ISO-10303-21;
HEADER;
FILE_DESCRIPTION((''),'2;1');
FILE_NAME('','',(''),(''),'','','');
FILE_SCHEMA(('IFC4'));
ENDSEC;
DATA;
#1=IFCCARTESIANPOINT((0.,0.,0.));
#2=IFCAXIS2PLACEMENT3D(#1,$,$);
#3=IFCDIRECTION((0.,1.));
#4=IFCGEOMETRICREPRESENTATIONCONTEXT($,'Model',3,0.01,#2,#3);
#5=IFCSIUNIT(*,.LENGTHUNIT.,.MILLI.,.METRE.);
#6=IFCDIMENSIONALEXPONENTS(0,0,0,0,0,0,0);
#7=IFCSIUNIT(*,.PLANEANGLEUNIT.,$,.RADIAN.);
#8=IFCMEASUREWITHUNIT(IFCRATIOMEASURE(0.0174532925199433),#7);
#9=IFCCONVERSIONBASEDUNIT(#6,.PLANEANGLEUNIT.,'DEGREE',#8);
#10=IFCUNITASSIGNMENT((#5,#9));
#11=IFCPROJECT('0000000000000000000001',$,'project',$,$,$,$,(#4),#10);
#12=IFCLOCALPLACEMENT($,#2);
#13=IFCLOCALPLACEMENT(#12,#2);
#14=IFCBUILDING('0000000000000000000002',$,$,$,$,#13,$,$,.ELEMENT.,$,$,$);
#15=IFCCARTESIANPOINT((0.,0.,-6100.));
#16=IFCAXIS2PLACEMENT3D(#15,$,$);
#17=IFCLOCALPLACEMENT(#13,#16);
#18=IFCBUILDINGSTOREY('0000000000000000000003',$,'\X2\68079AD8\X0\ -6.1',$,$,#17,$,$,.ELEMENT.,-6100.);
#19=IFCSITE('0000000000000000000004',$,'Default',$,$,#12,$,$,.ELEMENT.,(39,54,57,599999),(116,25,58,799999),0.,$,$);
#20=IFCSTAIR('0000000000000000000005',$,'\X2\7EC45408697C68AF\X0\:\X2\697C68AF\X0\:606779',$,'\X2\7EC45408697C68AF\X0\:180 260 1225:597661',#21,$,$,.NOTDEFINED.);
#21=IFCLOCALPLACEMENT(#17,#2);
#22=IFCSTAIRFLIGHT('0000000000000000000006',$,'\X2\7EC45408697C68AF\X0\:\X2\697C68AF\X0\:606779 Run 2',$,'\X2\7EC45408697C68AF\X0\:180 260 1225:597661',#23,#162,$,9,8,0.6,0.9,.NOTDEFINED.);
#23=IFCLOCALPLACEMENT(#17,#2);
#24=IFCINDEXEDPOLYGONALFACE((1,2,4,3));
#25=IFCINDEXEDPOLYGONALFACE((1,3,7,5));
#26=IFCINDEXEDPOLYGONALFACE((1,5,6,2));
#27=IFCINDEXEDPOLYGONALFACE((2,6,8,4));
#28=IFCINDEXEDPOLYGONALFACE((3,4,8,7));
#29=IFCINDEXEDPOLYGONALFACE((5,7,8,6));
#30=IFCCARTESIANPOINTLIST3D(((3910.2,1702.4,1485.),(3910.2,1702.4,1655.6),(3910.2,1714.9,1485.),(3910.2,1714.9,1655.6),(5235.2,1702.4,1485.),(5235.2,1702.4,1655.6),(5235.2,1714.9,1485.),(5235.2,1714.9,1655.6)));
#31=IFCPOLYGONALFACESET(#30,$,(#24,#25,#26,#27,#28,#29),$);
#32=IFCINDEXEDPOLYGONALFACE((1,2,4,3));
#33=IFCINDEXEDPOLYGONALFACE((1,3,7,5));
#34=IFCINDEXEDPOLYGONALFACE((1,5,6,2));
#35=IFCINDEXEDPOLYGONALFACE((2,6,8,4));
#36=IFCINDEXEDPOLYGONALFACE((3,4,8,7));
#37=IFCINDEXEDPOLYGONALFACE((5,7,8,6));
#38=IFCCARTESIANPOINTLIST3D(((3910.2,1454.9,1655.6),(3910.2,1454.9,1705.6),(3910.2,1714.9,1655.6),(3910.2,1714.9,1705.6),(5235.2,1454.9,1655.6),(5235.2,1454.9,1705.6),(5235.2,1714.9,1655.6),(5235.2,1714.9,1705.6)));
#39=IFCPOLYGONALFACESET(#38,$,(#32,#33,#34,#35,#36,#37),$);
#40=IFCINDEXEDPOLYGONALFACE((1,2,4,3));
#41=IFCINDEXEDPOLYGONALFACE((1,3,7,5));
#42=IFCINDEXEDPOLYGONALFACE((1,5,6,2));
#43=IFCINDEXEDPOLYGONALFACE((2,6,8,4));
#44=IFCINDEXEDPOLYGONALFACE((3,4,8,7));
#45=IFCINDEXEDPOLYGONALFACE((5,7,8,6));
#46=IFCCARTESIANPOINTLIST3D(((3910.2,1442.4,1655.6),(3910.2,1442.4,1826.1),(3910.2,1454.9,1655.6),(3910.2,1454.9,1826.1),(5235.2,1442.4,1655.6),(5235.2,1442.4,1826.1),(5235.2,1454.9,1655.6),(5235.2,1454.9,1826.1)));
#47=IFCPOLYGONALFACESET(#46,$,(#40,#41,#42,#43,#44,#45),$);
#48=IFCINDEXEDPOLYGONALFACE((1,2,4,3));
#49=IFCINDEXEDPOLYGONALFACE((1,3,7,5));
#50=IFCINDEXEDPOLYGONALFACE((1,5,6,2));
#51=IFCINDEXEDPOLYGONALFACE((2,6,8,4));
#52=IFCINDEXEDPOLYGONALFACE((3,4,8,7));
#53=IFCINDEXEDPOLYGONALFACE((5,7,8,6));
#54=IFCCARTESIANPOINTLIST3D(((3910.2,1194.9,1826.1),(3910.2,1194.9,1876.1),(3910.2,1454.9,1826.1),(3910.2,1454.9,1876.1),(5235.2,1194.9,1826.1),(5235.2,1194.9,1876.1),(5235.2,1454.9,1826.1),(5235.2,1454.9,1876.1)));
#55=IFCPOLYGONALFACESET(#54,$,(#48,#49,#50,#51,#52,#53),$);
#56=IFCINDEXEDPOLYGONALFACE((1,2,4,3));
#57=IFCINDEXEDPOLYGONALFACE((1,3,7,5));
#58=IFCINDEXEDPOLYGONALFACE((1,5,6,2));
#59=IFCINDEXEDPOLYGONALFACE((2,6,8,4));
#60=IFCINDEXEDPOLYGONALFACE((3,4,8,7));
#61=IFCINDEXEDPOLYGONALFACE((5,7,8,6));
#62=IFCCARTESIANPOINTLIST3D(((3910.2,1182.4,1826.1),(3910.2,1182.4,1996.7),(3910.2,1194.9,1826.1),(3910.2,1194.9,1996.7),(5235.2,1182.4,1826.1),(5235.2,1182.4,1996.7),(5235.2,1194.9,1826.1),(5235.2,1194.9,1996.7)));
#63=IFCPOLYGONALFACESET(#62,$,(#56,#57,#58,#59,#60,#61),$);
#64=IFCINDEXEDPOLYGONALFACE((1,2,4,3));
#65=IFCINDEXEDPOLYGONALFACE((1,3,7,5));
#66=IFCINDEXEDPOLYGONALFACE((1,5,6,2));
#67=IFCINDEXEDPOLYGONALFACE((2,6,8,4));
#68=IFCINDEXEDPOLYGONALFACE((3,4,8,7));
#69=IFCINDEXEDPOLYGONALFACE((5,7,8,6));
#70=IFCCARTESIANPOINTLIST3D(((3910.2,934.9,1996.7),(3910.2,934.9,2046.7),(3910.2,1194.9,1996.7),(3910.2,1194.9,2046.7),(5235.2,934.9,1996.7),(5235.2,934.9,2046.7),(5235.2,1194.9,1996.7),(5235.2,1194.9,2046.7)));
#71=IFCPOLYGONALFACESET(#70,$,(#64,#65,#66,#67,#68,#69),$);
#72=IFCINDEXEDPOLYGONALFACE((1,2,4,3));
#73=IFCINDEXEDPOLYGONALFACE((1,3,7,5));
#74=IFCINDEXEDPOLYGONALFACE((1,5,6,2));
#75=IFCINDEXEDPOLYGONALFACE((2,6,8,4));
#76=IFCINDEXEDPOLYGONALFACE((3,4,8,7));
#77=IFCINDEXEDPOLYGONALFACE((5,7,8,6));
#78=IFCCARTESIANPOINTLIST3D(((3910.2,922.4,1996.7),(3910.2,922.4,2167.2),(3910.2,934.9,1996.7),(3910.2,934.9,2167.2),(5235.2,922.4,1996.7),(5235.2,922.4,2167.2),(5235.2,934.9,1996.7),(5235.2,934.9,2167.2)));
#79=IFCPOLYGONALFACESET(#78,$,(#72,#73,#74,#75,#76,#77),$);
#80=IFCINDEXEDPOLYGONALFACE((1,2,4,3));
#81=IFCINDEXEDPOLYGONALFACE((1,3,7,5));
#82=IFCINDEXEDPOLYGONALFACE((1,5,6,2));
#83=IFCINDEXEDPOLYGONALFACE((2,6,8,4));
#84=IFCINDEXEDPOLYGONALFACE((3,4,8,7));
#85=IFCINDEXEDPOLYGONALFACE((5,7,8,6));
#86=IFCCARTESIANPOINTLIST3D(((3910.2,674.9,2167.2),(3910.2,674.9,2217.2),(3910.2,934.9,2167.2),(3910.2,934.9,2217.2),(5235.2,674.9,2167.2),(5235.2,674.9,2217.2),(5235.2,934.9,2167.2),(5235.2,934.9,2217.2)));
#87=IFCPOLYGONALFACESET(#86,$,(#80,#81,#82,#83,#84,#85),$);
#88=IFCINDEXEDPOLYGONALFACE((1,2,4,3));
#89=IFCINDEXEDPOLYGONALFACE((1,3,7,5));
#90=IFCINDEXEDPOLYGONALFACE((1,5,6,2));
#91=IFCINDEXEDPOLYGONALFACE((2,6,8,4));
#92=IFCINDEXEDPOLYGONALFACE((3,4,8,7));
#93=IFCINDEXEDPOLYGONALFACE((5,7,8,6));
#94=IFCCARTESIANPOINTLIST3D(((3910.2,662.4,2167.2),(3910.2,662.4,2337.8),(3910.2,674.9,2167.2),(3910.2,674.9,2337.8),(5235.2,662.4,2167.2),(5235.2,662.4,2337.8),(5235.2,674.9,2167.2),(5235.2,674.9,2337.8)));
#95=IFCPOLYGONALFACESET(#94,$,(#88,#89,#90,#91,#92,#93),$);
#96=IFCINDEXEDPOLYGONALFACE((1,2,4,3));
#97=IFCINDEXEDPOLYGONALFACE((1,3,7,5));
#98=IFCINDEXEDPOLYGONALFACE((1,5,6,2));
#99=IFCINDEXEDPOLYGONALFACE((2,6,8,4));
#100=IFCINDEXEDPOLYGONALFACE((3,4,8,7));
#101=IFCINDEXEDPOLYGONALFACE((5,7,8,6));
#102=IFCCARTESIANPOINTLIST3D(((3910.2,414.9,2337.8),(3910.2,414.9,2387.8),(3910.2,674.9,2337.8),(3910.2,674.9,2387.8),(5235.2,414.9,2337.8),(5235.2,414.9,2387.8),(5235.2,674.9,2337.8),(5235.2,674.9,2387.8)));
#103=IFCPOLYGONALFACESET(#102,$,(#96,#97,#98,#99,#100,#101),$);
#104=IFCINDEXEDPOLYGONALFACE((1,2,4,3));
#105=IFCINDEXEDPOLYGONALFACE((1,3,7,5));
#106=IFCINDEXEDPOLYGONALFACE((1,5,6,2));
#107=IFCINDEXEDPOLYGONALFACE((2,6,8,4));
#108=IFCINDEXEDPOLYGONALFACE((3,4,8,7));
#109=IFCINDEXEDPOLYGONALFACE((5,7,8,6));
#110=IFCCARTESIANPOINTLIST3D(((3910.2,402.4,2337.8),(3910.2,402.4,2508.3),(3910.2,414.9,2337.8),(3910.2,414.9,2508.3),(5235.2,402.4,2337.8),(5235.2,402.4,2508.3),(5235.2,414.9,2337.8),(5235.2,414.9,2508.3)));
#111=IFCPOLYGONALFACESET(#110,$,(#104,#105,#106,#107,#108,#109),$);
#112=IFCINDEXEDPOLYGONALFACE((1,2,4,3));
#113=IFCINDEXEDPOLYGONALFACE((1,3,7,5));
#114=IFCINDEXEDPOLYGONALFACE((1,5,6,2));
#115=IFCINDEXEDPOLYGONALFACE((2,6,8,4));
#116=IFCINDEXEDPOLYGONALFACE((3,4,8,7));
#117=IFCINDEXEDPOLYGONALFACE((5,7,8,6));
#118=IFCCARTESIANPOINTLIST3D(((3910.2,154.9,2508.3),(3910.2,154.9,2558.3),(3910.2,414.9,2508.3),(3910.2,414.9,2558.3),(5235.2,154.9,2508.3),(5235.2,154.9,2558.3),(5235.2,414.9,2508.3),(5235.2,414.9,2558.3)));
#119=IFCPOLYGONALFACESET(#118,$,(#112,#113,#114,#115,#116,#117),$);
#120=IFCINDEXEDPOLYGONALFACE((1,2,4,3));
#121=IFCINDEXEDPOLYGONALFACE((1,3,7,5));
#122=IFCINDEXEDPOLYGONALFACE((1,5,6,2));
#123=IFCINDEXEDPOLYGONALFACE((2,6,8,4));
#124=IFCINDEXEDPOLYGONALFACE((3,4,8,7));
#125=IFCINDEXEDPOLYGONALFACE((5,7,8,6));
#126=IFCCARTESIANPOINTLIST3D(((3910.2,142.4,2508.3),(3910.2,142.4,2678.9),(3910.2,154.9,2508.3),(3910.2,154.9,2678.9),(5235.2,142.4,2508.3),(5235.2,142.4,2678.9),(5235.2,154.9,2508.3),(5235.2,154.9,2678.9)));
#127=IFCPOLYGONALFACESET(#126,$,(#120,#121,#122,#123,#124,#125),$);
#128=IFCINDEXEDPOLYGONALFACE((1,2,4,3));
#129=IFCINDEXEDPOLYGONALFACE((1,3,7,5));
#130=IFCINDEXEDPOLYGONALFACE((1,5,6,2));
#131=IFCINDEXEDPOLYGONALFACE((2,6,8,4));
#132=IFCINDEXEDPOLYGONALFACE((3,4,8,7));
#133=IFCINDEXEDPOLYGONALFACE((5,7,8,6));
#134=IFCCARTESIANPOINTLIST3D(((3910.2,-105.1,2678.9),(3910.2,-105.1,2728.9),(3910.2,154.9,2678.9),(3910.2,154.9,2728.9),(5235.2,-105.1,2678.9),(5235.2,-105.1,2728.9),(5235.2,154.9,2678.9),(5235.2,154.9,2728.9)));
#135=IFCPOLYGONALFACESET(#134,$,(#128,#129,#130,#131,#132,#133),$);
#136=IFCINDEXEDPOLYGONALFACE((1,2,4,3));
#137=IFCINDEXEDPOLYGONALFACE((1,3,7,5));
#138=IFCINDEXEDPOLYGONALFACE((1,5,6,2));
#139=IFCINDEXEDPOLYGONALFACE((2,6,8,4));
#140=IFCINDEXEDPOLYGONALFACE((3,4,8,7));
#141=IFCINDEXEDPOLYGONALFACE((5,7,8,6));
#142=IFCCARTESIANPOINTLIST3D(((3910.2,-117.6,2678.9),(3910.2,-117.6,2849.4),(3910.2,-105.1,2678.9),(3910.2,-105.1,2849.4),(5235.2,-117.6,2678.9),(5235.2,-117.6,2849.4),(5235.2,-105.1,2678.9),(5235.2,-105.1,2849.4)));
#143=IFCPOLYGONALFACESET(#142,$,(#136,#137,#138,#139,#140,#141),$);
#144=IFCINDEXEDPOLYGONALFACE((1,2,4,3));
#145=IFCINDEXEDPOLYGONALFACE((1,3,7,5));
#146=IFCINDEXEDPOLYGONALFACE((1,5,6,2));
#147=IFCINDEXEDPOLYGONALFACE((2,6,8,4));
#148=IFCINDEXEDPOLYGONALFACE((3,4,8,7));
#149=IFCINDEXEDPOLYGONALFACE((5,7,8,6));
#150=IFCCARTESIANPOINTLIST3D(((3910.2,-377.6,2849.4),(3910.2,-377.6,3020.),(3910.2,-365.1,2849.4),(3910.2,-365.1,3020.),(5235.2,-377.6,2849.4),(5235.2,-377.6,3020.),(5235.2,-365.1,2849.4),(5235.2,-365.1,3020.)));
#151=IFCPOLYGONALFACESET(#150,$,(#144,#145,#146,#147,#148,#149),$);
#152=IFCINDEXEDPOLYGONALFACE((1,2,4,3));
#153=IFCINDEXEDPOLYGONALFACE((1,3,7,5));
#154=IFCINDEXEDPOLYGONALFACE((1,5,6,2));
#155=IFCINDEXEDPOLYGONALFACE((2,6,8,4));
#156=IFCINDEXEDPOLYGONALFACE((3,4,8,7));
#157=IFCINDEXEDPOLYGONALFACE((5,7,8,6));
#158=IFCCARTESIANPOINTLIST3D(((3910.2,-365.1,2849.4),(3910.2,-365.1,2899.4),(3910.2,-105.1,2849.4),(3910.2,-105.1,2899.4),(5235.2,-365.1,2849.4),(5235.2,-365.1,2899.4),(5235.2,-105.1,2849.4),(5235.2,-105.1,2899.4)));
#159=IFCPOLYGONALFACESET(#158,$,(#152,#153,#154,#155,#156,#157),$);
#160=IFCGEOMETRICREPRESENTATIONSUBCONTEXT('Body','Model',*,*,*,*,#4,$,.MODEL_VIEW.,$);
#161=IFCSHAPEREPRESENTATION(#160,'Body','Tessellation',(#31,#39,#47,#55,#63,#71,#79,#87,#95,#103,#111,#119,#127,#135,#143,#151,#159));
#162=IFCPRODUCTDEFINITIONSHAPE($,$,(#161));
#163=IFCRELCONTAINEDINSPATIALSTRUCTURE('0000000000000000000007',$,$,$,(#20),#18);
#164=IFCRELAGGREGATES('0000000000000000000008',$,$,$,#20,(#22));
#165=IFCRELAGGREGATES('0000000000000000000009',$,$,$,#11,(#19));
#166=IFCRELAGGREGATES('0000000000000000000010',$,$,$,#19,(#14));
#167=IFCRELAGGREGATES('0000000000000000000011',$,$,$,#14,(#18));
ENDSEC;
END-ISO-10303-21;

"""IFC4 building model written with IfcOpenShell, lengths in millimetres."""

from ifc_helpers import new_model, entity, si_unit, converted_unit, direction, frame, frame_2d, origin, origin_2d_with_axis, place, context, subcontext, project, spatial, rectangle, extrude, element, aggregate, save


model = new_model("IFC4")

# Units and contexts
model_context = context("Model", 3, precision=0.01, world=origin(), true_north=direction((0.0, 1.0)))
body_context = subcontext(model_context, "Body", "Model", "MODEL_VIEW")
ifc_project = project(units=[si_unit("LENGTHUNIT", "METRE", prefix="MILLI"), converted_unit("PLANEANGLEUNIT", "DEGREE", entity("IfcRatioMeasure", 0.0174532925199433), si_unit("PLANEANGLEUNIT", "RADIAN"), dimensions=[0, 0, 0, 0, 0, 0, 0])], contexts=[model_context])

# Site, building, storey
site_placement = place(None, origin())
site = spatial("IfcSite", under=ifc_project, at=site_placement, Name="Default", CompositionType="ELEMENT", RefLatitude=(39, 54, 57, 599999), RefLongitude=(116, 25, 58, 799999), RefElevation=0.0)
building_placement = place(site_placement, origin())
building = spatial("IfcBuilding", under=site, at=building_placement, CompositionType="ELEMENT")
storey_placement = place(building_placement, frame((0.0, 0.0, -6100.0)))
storey = spatial("IfcBuildingStorey", under=building, at=storey_placement, Name="标高 -6.1", CompositionType="ELEMENT", Elevation=-6100.0)

# Stair
stair_placement = place(storey_placement, origin())
stair = element("IfcStair", 1, at=stair_placement, inside=storey, Name="组合楼梯:楼梯:606779", ObjectType="组合楼梯:180 260 1225:597661", PredefinedType="NOTDEFINED")

# Stair flight
stair_flight_1_placement = place(stair_placement, frame((3910.2, -377.6, 0.0)))
stair_flight_1 = element("IfcStairFlight", 2, at=stair_flight_1_placement, Name="组合楼梯:楼梯:606779 Run 2", ObjectType="组合楼梯:180 260 1225:597661", NumberOfRisers=9, NumberOfTreads=8, PredefinedType="NOTDEFINED", RiserHeight=0.6, TreadLength=0.9, context=body_context, shape_type="SweptSolid", body=[
    extrude(rectangle(XDim=1325.0, YDim=12.5, at=frame_2d((0.0, 0.0), x_axis=(1.0, 0.0))), frame((662.5, 2086.2, 1485.0)), (0.0, 0.0, 1.0), 170.6),
    extrude(rectangle(XDim=260.0, YDim=1325.0, at=frame_2d((0.0, 0.0), x_axis=(1.0, 0.0))), frame((662.5, 1962.5, 1655.6), z_axis=(0.0, 0.0, 1.0), x_axis=(0.0, 1.0, 0.0)), (0.0, 0.0, 1.0), 50.0),
    extrude(rectangle(XDim=1325.0, YDim=12.5, at=origin_2d_with_axis()), frame((662.5, 1826.2, 1655.6)), (0.0, 0.0, 1.0), 170.6),
    extrude(rectangle(XDim=260.0, YDim=1325.0, at=frame_2d((0.0, 0.0), x_axis=(1.0, 0.0))), frame((662.5, 1702.5, 1826.1), z_axis=(0.0, 0.0, 1.0), x_axis=(0.0, 1.0, 0.0)), (0.0, 0.0, 1.0), 50.0),
    extrude(rectangle(XDim=1325.0, YDim=12.5, at=origin_2d_with_axis()), frame((662.5, 1566.2, 1826.1)), (0.0, 0.0, 1.0), 170.6),
    extrude(rectangle(XDim=260.0, YDim=1325.0, at=frame_2d((0.0, 0.0), x_axis=(1.0, 0.0))), frame((662.5, 1442.5, 1996.7), z_axis=(0.0, 0.0, 1.0), x_axis=(0.0, 1.0, 0.0)), (0.0, 0.0, 1.0), 50.0),
    extrude(rectangle(XDim=1325.0, YDim=12.5, at=origin_2d_with_axis()), frame((662.5, 1306.2, 1996.7)), (0.0, 0.0, 1.0), 170.6),
    extrude(rectangle(XDim=260.0, YDim=1325.0, at=frame_2d((0.0, 0.0), x_axis=(1.0, 0.0))), frame((662.5, 1182.5, 2167.2), z_axis=(0.0, 0.0, 1.0), x_axis=(0.0, 1.0, 0.0)), (0.0, 0.0, 1.0), 50.0),
    extrude(rectangle(XDim=1325.0, YDim=12.5, at=origin_2d_with_axis()), frame((662.5, 1046.2, 2167.2)), (0.0, 0.0, 1.0), 170.6),
    extrude(rectangle(XDim=260.0, YDim=1325.0, at=frame_2d((0.0, 0.0), x_axis=(1.0, 0.0))), frame((662.5, 922.5, 2337.8), z_axis=(0.0, 0.0, 1.0), x_axis=(0.0, 1.0, 0.0)), (0.0, 0.0, 1.0), 50.0),
    extrude(rectangle(XDim=1325.0, YDim=12.5, at=origin_2d_with_axis()), frame((662.5, 786.2, 2337.8)), (0.0, 0.0, 1.0), 170.6),
    extrude(rectangle(XDim=260.0, YDim=1325.0, at=frame_2d((0.0, 0.0), x_axis=(1.0, 0.0))), frame((662.5, 662.5, 2508.3), z_axis=(0.0, 0.0, 1.0), x_axis=(0.0, 1.0, 0.0)), (0.0, 0.0, 1.0), 50.0),
    extrude(rectangle(XDim=1325.0, YDim=12.5, at=origin_2d_with_axis()), frame((662.5, 526.2, 2508.3)), (0.0, 0.0, 1.0), 170.6),
    extrude(rectangle(XDim=260.0, YDim=1325.0, at=frame_2d((0.0, 0.0), x_axis=(1.0, 0.0))), frame((662.5, 402.5, 2678.9), z_axis=(0.0, 0.0, 1.0), x_axis=(0.0, 1.0, 0.0)), (0.0, 0.0, 1.0), 50.0),
    extrude(rectangle(XDim=1325.0, YDim=12.5, at=origin_2d_with_axis()), frame((662.5, 266.3, 2678.9)), (0.0, 0.0, 1.0), 170.6),
    extrude(rectangle(XDim=1325.0, YDim=12.5, at=origin_2d_with_axis()), frame((662.5, 6.2, 2849.4)), (0.0, 0.0, 1.0), 170.6),
    extrude(rectangle(XDim=260.0, YDim=1325.0, at=frame_2d((0.0, 0.0), x_axis=(1.0, 0.0))), frame((662.5, 142.5, 2849.4), z_axis=(0.0, 0.0, 1.0), x_axis=(0.0, 1.0, 0.0)), (0.0, 0.0, 1.0), 50.0),
])

aggregate(stair, [stair_flight_1])

save(model, "model.ifc")
